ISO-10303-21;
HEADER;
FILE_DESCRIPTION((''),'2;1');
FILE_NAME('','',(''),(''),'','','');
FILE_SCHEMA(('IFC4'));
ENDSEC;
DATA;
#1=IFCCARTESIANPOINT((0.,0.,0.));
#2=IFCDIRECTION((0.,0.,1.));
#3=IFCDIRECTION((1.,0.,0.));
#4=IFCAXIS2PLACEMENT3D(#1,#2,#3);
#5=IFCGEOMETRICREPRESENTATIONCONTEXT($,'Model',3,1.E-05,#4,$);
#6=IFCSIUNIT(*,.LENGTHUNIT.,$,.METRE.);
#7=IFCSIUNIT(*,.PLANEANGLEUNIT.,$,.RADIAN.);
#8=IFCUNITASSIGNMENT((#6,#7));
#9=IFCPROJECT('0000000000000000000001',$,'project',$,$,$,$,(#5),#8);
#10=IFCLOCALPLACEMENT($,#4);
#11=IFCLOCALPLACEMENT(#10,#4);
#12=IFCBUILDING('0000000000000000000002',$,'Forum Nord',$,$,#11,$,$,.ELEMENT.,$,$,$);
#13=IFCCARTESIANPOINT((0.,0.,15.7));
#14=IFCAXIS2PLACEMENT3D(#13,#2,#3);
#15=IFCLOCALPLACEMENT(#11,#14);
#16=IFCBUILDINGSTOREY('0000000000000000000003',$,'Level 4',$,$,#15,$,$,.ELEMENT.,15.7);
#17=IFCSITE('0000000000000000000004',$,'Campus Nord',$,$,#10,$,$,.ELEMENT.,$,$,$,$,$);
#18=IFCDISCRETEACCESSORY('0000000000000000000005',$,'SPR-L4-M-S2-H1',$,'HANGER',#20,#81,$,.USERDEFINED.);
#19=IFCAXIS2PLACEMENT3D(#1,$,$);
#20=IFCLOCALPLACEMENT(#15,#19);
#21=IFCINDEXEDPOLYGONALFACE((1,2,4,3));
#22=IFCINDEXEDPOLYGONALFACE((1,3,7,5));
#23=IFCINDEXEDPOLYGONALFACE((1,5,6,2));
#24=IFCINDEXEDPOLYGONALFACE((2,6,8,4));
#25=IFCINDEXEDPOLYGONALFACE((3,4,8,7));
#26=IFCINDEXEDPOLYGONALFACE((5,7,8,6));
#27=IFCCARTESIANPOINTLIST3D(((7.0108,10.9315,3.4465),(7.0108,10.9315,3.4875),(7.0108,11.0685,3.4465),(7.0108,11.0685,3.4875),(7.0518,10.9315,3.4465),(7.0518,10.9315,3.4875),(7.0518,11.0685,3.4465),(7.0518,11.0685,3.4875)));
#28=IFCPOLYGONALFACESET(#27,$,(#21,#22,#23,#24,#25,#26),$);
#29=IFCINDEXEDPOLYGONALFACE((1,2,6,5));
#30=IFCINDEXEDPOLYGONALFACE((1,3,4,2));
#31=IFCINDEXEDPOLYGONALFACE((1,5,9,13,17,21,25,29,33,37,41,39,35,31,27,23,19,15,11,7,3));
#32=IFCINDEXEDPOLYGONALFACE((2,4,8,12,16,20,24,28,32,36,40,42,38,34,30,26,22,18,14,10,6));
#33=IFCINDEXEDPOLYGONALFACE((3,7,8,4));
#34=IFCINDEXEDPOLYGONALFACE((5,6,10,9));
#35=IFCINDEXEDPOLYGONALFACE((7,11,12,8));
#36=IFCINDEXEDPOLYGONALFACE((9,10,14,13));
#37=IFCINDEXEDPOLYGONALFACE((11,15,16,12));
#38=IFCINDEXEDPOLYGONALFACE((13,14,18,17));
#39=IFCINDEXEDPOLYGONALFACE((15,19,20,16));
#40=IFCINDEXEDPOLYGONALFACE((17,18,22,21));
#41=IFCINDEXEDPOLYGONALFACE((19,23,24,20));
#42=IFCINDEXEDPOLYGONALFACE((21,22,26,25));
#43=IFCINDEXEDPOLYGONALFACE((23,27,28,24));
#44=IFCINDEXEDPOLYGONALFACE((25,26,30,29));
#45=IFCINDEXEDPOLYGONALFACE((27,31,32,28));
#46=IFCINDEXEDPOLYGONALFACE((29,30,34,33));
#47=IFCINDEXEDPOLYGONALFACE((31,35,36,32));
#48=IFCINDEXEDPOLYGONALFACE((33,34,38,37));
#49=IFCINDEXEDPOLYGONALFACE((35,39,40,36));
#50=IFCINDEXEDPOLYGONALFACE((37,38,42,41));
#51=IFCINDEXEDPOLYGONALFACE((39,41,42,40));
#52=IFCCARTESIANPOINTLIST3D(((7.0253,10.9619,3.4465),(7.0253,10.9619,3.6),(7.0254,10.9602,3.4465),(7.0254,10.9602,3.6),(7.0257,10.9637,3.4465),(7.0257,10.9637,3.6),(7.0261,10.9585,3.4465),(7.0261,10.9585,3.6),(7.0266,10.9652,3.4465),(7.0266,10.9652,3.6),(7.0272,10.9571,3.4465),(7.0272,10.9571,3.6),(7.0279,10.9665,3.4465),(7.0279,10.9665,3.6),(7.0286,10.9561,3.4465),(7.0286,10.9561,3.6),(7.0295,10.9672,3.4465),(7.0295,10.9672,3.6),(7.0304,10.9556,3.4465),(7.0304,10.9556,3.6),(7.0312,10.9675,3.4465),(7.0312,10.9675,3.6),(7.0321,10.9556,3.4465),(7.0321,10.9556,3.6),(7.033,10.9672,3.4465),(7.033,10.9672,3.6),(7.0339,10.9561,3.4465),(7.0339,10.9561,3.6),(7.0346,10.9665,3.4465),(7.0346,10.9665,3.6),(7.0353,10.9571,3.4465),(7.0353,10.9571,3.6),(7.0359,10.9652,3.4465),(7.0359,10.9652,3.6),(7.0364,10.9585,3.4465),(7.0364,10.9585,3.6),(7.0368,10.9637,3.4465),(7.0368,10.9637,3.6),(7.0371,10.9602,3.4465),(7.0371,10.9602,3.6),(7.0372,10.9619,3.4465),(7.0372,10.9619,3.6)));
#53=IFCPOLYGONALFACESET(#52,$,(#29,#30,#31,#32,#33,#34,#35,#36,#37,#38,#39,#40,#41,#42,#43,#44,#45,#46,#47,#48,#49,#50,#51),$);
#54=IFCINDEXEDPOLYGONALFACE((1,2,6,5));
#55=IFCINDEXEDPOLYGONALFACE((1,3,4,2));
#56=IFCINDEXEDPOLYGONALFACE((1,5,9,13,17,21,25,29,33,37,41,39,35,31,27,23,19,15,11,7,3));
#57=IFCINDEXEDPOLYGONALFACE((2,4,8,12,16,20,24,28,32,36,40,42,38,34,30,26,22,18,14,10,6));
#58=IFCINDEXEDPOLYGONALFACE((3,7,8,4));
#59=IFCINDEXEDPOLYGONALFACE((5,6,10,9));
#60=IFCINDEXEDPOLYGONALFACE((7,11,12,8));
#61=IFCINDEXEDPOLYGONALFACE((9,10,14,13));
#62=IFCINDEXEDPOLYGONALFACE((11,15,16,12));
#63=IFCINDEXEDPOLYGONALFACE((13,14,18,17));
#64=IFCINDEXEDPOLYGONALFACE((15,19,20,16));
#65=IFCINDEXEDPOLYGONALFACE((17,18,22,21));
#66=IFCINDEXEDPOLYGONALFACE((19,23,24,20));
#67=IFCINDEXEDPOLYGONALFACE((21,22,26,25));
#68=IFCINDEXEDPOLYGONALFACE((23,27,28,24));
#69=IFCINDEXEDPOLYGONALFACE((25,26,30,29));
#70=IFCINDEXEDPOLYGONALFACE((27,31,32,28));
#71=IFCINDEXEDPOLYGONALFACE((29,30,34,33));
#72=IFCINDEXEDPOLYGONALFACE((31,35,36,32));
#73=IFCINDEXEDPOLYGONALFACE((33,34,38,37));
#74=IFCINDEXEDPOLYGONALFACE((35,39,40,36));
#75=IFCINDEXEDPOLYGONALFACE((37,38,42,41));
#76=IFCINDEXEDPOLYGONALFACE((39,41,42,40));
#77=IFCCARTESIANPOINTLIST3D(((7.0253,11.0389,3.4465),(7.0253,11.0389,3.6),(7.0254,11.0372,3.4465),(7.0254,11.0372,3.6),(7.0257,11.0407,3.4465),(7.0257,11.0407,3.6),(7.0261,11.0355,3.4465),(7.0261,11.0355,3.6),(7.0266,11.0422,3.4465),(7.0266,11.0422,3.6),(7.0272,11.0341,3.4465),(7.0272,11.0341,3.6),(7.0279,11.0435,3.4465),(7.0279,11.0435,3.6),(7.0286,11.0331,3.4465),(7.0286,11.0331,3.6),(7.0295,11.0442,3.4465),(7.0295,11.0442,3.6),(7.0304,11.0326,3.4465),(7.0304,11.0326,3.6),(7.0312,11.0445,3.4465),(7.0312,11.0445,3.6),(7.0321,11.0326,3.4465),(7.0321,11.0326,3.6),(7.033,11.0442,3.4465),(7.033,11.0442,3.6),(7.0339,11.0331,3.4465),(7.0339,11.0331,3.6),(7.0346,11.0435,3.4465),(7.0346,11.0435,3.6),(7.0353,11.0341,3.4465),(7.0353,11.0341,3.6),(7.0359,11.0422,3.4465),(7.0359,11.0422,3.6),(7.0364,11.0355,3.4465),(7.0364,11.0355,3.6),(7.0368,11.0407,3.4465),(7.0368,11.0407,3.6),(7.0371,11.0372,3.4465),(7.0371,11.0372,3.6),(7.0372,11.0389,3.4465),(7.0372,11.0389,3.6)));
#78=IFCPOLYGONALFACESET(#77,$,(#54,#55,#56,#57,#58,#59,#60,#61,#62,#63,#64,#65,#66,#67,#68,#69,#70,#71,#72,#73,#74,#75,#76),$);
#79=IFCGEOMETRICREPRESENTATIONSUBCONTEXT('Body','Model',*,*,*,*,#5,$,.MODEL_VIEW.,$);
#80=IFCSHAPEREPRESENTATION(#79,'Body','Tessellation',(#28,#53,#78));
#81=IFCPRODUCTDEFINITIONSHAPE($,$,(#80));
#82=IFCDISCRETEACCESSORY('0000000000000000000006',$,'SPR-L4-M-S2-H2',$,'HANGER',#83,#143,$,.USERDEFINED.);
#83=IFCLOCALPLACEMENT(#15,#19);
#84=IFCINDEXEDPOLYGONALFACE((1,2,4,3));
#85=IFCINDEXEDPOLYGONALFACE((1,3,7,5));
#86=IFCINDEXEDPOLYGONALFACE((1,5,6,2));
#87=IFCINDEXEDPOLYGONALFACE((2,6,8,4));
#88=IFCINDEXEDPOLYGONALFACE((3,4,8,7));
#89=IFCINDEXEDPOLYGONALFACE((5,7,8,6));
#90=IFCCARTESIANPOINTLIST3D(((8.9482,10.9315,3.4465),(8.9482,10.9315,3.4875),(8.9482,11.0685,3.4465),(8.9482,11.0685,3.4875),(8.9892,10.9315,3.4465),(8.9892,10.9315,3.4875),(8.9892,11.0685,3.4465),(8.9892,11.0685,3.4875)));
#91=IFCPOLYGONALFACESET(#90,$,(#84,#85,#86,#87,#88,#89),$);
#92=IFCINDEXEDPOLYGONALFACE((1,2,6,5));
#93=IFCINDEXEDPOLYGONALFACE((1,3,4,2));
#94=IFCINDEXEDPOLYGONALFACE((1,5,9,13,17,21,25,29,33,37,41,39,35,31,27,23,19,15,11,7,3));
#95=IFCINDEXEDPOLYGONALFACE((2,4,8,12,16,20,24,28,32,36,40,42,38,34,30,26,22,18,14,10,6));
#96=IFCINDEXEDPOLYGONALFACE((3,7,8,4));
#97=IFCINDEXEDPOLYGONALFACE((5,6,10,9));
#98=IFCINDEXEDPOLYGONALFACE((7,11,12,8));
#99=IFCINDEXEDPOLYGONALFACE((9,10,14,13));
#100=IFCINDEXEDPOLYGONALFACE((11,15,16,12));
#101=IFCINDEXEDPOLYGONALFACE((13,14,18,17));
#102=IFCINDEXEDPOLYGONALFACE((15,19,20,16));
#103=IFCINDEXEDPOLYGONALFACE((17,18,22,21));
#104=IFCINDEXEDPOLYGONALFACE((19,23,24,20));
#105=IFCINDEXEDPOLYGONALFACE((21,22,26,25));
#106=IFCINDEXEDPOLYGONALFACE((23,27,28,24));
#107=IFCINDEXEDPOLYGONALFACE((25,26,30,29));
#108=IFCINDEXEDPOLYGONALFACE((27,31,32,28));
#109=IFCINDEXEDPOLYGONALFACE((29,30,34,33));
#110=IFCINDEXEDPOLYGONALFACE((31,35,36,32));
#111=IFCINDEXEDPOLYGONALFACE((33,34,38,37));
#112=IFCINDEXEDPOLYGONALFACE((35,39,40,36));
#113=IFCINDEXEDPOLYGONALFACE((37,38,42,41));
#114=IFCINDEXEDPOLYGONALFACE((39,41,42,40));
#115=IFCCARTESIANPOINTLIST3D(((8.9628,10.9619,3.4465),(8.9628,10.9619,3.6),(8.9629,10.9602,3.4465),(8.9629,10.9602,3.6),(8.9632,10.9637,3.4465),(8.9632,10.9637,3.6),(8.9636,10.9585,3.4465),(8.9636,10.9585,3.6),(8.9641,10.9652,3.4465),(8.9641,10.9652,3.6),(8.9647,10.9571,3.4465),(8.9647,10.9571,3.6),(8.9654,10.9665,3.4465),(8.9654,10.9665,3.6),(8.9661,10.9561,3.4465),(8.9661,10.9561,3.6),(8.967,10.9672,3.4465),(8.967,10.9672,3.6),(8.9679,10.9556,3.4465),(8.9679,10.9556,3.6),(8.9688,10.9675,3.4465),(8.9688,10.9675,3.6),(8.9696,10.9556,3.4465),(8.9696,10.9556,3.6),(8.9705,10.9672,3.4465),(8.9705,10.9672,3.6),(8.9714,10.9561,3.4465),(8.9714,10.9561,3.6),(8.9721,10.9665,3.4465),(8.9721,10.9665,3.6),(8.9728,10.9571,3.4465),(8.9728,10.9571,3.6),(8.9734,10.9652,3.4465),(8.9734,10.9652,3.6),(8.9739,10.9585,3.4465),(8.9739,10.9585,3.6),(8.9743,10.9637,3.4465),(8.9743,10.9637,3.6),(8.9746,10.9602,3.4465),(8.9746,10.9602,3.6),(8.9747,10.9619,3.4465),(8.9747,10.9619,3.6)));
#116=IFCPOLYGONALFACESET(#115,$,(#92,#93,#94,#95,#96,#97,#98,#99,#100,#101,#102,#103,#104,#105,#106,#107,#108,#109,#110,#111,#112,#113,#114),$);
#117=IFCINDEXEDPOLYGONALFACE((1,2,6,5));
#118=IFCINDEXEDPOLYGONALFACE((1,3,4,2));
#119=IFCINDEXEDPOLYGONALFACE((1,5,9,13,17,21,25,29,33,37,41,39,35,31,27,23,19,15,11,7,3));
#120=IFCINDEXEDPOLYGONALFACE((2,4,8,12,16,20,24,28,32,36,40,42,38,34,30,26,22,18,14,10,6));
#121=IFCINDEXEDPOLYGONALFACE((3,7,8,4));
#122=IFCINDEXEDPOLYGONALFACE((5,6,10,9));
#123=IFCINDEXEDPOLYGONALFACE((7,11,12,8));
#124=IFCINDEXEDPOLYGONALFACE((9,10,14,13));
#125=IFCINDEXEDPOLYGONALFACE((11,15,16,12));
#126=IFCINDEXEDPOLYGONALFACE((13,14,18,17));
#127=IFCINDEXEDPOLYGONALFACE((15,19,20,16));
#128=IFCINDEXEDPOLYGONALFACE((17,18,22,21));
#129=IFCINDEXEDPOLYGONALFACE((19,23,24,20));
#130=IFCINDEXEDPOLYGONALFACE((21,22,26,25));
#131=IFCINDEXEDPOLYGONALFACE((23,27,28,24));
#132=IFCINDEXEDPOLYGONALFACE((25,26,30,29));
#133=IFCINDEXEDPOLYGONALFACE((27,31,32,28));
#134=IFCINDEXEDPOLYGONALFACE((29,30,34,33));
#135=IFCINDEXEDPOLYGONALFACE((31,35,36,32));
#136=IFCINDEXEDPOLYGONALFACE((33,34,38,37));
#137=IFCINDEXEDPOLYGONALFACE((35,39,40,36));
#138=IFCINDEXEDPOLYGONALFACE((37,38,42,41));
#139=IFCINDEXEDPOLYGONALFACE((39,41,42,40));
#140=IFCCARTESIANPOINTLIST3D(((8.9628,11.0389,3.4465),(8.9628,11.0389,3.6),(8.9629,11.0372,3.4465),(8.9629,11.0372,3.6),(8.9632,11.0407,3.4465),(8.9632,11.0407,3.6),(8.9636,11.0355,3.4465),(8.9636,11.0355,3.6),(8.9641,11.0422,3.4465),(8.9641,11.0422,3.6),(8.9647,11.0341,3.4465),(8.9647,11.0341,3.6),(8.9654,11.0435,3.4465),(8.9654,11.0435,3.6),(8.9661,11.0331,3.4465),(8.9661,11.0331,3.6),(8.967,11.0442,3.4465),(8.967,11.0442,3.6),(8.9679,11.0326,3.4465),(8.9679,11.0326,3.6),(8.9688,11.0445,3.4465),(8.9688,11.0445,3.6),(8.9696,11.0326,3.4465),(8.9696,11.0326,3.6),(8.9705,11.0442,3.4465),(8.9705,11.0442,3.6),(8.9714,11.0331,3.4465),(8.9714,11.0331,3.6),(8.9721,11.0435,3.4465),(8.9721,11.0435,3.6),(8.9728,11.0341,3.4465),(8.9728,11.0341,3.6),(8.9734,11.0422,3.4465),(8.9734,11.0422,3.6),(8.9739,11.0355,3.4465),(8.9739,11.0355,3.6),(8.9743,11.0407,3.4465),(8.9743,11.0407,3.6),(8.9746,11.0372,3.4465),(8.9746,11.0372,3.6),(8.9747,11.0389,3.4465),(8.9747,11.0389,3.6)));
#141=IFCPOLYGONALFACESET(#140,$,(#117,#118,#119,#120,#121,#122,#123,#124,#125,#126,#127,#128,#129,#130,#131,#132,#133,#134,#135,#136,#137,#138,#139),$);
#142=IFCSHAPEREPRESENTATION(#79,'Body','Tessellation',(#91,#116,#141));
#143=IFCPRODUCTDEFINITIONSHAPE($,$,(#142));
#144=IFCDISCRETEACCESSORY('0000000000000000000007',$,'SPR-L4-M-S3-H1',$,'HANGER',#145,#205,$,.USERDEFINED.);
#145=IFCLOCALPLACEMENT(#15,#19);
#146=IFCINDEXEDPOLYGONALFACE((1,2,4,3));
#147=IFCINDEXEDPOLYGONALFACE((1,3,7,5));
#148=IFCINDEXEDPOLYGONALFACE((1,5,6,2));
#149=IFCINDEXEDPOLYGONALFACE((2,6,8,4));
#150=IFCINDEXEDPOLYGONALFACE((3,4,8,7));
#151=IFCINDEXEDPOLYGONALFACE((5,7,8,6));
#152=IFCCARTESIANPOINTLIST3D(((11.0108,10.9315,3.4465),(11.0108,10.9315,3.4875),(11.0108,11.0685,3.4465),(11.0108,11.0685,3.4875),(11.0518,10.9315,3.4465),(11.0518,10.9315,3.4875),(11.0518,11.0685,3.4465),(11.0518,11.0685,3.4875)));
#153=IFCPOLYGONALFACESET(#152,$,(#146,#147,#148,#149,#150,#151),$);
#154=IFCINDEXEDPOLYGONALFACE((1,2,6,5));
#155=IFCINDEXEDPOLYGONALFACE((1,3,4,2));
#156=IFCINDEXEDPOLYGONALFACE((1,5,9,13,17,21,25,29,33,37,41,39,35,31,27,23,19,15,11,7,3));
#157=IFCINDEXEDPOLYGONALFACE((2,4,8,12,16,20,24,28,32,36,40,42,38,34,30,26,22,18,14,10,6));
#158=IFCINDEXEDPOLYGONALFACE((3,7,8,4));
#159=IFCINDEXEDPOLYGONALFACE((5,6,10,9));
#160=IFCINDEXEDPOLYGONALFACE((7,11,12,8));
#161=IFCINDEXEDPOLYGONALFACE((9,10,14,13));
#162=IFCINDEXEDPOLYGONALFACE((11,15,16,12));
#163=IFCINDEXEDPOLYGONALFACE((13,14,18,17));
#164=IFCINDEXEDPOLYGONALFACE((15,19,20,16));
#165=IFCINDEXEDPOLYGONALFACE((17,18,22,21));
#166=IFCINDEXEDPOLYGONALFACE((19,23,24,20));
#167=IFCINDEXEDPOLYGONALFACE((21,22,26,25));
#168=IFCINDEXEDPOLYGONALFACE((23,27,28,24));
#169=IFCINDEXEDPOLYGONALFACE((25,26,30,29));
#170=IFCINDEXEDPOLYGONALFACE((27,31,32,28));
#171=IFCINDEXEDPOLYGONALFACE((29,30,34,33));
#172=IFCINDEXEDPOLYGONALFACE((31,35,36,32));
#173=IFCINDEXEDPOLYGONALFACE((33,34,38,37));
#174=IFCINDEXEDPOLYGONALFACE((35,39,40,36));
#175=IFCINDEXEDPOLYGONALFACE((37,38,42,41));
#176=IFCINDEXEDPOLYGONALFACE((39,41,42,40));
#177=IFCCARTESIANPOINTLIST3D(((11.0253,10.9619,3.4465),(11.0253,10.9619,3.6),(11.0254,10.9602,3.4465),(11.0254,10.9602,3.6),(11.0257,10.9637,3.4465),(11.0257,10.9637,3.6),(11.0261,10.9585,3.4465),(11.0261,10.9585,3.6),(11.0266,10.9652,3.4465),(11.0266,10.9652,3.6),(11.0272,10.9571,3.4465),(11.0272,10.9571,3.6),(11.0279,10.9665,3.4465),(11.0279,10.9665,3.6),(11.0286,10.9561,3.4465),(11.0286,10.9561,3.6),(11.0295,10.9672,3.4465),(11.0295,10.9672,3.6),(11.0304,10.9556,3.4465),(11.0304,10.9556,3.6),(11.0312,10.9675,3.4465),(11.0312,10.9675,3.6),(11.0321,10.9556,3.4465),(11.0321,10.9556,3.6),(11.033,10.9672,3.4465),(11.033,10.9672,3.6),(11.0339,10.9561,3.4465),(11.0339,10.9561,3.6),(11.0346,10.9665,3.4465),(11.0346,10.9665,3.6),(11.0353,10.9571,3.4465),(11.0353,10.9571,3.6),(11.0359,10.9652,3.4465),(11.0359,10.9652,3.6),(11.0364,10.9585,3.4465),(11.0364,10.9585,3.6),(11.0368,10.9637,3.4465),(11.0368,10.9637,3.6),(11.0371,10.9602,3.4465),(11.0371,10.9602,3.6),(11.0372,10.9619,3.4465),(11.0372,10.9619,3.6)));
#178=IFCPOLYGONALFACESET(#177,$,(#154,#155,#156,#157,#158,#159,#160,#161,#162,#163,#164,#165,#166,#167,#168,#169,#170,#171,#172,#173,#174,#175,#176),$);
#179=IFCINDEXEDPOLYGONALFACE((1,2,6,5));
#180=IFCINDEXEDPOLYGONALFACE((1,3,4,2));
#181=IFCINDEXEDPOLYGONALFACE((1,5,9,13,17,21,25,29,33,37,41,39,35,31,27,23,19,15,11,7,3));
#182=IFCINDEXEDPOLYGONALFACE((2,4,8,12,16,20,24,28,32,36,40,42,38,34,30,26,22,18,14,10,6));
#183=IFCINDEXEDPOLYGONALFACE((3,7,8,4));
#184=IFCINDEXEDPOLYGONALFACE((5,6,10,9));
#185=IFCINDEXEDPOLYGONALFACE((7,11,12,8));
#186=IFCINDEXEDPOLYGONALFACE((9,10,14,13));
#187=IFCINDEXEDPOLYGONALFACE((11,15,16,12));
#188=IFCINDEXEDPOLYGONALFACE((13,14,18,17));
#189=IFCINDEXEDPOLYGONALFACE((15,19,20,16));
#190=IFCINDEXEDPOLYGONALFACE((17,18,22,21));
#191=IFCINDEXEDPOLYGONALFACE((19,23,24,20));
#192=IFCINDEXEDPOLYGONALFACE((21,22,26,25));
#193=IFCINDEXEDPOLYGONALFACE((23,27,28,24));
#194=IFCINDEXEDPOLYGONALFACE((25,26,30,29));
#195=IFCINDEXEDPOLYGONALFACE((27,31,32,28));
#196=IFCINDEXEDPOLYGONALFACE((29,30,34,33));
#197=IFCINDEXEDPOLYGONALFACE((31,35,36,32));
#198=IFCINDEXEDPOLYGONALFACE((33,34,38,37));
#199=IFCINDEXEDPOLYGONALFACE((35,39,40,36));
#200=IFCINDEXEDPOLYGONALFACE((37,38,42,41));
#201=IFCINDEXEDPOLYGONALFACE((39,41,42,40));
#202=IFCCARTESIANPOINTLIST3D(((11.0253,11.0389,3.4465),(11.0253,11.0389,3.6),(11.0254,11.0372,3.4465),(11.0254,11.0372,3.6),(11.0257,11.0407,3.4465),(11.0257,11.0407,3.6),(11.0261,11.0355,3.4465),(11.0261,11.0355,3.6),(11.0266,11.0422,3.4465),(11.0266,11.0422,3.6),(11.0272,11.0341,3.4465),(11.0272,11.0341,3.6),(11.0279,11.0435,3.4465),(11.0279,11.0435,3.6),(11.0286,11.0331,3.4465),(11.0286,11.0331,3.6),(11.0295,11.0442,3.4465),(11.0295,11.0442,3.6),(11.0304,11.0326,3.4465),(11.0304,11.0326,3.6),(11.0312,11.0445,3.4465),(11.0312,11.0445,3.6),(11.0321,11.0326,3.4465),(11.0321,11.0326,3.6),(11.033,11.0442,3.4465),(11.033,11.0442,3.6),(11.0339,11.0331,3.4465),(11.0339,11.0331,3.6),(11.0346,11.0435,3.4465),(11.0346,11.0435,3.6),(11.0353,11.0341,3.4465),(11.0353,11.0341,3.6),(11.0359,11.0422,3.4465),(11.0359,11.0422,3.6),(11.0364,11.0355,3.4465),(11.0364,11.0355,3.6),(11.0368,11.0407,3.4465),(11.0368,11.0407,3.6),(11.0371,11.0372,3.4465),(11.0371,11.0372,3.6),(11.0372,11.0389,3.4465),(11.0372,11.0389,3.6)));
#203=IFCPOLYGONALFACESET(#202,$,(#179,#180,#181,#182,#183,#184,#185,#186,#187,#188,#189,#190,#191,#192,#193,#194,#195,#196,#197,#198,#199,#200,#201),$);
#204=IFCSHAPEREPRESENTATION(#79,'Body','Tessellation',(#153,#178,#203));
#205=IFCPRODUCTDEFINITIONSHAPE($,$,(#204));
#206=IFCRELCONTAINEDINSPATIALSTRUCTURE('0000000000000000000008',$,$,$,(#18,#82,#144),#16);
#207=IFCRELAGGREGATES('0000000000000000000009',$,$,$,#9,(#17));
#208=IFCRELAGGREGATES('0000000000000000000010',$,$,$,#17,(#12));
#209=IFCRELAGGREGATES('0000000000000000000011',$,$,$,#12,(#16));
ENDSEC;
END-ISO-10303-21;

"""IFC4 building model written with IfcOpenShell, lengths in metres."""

from ifc_helpers import new_model, si_unit, frame, frame_2d, origin_with_axes, origin_2d_with_axis, place, context, subcontext, project, spatial, rectangle, circle, extrude, element, save


model = new_model("IFC4")

# Units and contexts
model_context = context("Model", 3, precision=1e-05, world=origin_with_axes())
body_context = subcontext(model_context, "Body", "Model", "MODEL_VIEW")
ifc_project = project(units=[si_unit("LENGTHUNIT", "METRE"), si_unit("PLANEANGLEUNIT", "RADIAN")], contexts=[model_context])

# Site, building, storey
site_placement = place(None, origin_with_axes())
site = spatial("IfcSite", under=ifc_project, at=site_placement, Name="Campus Nord", CompositionType="ELEMENT")
building_placement = place(site_placement, origin_with_axes())
building = spatial("IfcBuilding", under=site, at=building_placement, Name="Forum Nord", CompositionType="ELEMENT")
storey_placement = place(building_placement, frame((0.0, 0.0, 15.7), z_axis=(0.0, 0.0, 1.0), x_axis=(1.0, 0.0, 0.0)))
storey = spatial("IfcBuildingStorey", under=building, at=storey_placement, Name="Level 4", CompositionType="ELEMENT", Elevation=15.7)

# Discrete accessories
for number, where, z_axis, x_axis, name in (
    (1, (7.0312, 11.0, 3.4875), (0.0, 0.0, 1.0), (0.0, 1.0, 0.0), "SPR-L4-M-S2-H1"),
    (2, (8.9688, 11.0, 3.4875), (0.0, 0.0, 1.0), (0.0, 1.0, 0.0), "SPR-L4-M-S2-H2"),
    (3, (11.0312, 11.0, 3.4875), (0.0, 0.0, 1.0), (0.0, 1.0, 0.0), "SPR-L4-M-S3-H1"),
):
    element("IfcDiscreteAccessory", number, at=place(storey_placement, frame(where, z_axis=z_axis, x_axis=x_axis)), inside=storey, Name=name, ObjectType="HANGER", PredefinedType="USERDEFINED", context=body_context, shape_type="SweptSolid", body=[
        extrude(rectangle(XDim=0.137, YDim=0.041, at=origin_2d_with_axis()), frame((0.0, 0.0, -0.041), z_axis=(0.0, 0.0, 1.0), x_axis=(1.0, 0.0, 0.0)), (0.0, 0.0, 1.0), 0.041),
        extrude(circle(Radius=0.006, at=frame_2d((-0.0385, 0.0), x_axis=(1.0, 0.0))), frame((0.0, 0.0, -0.041), z_axis=(0.0, 0.0, 1.0), x_axis=(1.0, 0.0, 0.0)), (0.0, 0.0, 1.0), 0.1535),
        extrude(circle(Radius=0.006, at=frame_2d((0.0385, 0.0), x_axis=(1.0, 0.0))), frame((0.0, 0.0, -0.041), z_axis=(0.0, 0.0, 1.0), x_axis=(1.0, 0.0, 0.0)), (0.0, 0.0, 1.0), 0.1535),
    ])

save(model, "model.ifc")
